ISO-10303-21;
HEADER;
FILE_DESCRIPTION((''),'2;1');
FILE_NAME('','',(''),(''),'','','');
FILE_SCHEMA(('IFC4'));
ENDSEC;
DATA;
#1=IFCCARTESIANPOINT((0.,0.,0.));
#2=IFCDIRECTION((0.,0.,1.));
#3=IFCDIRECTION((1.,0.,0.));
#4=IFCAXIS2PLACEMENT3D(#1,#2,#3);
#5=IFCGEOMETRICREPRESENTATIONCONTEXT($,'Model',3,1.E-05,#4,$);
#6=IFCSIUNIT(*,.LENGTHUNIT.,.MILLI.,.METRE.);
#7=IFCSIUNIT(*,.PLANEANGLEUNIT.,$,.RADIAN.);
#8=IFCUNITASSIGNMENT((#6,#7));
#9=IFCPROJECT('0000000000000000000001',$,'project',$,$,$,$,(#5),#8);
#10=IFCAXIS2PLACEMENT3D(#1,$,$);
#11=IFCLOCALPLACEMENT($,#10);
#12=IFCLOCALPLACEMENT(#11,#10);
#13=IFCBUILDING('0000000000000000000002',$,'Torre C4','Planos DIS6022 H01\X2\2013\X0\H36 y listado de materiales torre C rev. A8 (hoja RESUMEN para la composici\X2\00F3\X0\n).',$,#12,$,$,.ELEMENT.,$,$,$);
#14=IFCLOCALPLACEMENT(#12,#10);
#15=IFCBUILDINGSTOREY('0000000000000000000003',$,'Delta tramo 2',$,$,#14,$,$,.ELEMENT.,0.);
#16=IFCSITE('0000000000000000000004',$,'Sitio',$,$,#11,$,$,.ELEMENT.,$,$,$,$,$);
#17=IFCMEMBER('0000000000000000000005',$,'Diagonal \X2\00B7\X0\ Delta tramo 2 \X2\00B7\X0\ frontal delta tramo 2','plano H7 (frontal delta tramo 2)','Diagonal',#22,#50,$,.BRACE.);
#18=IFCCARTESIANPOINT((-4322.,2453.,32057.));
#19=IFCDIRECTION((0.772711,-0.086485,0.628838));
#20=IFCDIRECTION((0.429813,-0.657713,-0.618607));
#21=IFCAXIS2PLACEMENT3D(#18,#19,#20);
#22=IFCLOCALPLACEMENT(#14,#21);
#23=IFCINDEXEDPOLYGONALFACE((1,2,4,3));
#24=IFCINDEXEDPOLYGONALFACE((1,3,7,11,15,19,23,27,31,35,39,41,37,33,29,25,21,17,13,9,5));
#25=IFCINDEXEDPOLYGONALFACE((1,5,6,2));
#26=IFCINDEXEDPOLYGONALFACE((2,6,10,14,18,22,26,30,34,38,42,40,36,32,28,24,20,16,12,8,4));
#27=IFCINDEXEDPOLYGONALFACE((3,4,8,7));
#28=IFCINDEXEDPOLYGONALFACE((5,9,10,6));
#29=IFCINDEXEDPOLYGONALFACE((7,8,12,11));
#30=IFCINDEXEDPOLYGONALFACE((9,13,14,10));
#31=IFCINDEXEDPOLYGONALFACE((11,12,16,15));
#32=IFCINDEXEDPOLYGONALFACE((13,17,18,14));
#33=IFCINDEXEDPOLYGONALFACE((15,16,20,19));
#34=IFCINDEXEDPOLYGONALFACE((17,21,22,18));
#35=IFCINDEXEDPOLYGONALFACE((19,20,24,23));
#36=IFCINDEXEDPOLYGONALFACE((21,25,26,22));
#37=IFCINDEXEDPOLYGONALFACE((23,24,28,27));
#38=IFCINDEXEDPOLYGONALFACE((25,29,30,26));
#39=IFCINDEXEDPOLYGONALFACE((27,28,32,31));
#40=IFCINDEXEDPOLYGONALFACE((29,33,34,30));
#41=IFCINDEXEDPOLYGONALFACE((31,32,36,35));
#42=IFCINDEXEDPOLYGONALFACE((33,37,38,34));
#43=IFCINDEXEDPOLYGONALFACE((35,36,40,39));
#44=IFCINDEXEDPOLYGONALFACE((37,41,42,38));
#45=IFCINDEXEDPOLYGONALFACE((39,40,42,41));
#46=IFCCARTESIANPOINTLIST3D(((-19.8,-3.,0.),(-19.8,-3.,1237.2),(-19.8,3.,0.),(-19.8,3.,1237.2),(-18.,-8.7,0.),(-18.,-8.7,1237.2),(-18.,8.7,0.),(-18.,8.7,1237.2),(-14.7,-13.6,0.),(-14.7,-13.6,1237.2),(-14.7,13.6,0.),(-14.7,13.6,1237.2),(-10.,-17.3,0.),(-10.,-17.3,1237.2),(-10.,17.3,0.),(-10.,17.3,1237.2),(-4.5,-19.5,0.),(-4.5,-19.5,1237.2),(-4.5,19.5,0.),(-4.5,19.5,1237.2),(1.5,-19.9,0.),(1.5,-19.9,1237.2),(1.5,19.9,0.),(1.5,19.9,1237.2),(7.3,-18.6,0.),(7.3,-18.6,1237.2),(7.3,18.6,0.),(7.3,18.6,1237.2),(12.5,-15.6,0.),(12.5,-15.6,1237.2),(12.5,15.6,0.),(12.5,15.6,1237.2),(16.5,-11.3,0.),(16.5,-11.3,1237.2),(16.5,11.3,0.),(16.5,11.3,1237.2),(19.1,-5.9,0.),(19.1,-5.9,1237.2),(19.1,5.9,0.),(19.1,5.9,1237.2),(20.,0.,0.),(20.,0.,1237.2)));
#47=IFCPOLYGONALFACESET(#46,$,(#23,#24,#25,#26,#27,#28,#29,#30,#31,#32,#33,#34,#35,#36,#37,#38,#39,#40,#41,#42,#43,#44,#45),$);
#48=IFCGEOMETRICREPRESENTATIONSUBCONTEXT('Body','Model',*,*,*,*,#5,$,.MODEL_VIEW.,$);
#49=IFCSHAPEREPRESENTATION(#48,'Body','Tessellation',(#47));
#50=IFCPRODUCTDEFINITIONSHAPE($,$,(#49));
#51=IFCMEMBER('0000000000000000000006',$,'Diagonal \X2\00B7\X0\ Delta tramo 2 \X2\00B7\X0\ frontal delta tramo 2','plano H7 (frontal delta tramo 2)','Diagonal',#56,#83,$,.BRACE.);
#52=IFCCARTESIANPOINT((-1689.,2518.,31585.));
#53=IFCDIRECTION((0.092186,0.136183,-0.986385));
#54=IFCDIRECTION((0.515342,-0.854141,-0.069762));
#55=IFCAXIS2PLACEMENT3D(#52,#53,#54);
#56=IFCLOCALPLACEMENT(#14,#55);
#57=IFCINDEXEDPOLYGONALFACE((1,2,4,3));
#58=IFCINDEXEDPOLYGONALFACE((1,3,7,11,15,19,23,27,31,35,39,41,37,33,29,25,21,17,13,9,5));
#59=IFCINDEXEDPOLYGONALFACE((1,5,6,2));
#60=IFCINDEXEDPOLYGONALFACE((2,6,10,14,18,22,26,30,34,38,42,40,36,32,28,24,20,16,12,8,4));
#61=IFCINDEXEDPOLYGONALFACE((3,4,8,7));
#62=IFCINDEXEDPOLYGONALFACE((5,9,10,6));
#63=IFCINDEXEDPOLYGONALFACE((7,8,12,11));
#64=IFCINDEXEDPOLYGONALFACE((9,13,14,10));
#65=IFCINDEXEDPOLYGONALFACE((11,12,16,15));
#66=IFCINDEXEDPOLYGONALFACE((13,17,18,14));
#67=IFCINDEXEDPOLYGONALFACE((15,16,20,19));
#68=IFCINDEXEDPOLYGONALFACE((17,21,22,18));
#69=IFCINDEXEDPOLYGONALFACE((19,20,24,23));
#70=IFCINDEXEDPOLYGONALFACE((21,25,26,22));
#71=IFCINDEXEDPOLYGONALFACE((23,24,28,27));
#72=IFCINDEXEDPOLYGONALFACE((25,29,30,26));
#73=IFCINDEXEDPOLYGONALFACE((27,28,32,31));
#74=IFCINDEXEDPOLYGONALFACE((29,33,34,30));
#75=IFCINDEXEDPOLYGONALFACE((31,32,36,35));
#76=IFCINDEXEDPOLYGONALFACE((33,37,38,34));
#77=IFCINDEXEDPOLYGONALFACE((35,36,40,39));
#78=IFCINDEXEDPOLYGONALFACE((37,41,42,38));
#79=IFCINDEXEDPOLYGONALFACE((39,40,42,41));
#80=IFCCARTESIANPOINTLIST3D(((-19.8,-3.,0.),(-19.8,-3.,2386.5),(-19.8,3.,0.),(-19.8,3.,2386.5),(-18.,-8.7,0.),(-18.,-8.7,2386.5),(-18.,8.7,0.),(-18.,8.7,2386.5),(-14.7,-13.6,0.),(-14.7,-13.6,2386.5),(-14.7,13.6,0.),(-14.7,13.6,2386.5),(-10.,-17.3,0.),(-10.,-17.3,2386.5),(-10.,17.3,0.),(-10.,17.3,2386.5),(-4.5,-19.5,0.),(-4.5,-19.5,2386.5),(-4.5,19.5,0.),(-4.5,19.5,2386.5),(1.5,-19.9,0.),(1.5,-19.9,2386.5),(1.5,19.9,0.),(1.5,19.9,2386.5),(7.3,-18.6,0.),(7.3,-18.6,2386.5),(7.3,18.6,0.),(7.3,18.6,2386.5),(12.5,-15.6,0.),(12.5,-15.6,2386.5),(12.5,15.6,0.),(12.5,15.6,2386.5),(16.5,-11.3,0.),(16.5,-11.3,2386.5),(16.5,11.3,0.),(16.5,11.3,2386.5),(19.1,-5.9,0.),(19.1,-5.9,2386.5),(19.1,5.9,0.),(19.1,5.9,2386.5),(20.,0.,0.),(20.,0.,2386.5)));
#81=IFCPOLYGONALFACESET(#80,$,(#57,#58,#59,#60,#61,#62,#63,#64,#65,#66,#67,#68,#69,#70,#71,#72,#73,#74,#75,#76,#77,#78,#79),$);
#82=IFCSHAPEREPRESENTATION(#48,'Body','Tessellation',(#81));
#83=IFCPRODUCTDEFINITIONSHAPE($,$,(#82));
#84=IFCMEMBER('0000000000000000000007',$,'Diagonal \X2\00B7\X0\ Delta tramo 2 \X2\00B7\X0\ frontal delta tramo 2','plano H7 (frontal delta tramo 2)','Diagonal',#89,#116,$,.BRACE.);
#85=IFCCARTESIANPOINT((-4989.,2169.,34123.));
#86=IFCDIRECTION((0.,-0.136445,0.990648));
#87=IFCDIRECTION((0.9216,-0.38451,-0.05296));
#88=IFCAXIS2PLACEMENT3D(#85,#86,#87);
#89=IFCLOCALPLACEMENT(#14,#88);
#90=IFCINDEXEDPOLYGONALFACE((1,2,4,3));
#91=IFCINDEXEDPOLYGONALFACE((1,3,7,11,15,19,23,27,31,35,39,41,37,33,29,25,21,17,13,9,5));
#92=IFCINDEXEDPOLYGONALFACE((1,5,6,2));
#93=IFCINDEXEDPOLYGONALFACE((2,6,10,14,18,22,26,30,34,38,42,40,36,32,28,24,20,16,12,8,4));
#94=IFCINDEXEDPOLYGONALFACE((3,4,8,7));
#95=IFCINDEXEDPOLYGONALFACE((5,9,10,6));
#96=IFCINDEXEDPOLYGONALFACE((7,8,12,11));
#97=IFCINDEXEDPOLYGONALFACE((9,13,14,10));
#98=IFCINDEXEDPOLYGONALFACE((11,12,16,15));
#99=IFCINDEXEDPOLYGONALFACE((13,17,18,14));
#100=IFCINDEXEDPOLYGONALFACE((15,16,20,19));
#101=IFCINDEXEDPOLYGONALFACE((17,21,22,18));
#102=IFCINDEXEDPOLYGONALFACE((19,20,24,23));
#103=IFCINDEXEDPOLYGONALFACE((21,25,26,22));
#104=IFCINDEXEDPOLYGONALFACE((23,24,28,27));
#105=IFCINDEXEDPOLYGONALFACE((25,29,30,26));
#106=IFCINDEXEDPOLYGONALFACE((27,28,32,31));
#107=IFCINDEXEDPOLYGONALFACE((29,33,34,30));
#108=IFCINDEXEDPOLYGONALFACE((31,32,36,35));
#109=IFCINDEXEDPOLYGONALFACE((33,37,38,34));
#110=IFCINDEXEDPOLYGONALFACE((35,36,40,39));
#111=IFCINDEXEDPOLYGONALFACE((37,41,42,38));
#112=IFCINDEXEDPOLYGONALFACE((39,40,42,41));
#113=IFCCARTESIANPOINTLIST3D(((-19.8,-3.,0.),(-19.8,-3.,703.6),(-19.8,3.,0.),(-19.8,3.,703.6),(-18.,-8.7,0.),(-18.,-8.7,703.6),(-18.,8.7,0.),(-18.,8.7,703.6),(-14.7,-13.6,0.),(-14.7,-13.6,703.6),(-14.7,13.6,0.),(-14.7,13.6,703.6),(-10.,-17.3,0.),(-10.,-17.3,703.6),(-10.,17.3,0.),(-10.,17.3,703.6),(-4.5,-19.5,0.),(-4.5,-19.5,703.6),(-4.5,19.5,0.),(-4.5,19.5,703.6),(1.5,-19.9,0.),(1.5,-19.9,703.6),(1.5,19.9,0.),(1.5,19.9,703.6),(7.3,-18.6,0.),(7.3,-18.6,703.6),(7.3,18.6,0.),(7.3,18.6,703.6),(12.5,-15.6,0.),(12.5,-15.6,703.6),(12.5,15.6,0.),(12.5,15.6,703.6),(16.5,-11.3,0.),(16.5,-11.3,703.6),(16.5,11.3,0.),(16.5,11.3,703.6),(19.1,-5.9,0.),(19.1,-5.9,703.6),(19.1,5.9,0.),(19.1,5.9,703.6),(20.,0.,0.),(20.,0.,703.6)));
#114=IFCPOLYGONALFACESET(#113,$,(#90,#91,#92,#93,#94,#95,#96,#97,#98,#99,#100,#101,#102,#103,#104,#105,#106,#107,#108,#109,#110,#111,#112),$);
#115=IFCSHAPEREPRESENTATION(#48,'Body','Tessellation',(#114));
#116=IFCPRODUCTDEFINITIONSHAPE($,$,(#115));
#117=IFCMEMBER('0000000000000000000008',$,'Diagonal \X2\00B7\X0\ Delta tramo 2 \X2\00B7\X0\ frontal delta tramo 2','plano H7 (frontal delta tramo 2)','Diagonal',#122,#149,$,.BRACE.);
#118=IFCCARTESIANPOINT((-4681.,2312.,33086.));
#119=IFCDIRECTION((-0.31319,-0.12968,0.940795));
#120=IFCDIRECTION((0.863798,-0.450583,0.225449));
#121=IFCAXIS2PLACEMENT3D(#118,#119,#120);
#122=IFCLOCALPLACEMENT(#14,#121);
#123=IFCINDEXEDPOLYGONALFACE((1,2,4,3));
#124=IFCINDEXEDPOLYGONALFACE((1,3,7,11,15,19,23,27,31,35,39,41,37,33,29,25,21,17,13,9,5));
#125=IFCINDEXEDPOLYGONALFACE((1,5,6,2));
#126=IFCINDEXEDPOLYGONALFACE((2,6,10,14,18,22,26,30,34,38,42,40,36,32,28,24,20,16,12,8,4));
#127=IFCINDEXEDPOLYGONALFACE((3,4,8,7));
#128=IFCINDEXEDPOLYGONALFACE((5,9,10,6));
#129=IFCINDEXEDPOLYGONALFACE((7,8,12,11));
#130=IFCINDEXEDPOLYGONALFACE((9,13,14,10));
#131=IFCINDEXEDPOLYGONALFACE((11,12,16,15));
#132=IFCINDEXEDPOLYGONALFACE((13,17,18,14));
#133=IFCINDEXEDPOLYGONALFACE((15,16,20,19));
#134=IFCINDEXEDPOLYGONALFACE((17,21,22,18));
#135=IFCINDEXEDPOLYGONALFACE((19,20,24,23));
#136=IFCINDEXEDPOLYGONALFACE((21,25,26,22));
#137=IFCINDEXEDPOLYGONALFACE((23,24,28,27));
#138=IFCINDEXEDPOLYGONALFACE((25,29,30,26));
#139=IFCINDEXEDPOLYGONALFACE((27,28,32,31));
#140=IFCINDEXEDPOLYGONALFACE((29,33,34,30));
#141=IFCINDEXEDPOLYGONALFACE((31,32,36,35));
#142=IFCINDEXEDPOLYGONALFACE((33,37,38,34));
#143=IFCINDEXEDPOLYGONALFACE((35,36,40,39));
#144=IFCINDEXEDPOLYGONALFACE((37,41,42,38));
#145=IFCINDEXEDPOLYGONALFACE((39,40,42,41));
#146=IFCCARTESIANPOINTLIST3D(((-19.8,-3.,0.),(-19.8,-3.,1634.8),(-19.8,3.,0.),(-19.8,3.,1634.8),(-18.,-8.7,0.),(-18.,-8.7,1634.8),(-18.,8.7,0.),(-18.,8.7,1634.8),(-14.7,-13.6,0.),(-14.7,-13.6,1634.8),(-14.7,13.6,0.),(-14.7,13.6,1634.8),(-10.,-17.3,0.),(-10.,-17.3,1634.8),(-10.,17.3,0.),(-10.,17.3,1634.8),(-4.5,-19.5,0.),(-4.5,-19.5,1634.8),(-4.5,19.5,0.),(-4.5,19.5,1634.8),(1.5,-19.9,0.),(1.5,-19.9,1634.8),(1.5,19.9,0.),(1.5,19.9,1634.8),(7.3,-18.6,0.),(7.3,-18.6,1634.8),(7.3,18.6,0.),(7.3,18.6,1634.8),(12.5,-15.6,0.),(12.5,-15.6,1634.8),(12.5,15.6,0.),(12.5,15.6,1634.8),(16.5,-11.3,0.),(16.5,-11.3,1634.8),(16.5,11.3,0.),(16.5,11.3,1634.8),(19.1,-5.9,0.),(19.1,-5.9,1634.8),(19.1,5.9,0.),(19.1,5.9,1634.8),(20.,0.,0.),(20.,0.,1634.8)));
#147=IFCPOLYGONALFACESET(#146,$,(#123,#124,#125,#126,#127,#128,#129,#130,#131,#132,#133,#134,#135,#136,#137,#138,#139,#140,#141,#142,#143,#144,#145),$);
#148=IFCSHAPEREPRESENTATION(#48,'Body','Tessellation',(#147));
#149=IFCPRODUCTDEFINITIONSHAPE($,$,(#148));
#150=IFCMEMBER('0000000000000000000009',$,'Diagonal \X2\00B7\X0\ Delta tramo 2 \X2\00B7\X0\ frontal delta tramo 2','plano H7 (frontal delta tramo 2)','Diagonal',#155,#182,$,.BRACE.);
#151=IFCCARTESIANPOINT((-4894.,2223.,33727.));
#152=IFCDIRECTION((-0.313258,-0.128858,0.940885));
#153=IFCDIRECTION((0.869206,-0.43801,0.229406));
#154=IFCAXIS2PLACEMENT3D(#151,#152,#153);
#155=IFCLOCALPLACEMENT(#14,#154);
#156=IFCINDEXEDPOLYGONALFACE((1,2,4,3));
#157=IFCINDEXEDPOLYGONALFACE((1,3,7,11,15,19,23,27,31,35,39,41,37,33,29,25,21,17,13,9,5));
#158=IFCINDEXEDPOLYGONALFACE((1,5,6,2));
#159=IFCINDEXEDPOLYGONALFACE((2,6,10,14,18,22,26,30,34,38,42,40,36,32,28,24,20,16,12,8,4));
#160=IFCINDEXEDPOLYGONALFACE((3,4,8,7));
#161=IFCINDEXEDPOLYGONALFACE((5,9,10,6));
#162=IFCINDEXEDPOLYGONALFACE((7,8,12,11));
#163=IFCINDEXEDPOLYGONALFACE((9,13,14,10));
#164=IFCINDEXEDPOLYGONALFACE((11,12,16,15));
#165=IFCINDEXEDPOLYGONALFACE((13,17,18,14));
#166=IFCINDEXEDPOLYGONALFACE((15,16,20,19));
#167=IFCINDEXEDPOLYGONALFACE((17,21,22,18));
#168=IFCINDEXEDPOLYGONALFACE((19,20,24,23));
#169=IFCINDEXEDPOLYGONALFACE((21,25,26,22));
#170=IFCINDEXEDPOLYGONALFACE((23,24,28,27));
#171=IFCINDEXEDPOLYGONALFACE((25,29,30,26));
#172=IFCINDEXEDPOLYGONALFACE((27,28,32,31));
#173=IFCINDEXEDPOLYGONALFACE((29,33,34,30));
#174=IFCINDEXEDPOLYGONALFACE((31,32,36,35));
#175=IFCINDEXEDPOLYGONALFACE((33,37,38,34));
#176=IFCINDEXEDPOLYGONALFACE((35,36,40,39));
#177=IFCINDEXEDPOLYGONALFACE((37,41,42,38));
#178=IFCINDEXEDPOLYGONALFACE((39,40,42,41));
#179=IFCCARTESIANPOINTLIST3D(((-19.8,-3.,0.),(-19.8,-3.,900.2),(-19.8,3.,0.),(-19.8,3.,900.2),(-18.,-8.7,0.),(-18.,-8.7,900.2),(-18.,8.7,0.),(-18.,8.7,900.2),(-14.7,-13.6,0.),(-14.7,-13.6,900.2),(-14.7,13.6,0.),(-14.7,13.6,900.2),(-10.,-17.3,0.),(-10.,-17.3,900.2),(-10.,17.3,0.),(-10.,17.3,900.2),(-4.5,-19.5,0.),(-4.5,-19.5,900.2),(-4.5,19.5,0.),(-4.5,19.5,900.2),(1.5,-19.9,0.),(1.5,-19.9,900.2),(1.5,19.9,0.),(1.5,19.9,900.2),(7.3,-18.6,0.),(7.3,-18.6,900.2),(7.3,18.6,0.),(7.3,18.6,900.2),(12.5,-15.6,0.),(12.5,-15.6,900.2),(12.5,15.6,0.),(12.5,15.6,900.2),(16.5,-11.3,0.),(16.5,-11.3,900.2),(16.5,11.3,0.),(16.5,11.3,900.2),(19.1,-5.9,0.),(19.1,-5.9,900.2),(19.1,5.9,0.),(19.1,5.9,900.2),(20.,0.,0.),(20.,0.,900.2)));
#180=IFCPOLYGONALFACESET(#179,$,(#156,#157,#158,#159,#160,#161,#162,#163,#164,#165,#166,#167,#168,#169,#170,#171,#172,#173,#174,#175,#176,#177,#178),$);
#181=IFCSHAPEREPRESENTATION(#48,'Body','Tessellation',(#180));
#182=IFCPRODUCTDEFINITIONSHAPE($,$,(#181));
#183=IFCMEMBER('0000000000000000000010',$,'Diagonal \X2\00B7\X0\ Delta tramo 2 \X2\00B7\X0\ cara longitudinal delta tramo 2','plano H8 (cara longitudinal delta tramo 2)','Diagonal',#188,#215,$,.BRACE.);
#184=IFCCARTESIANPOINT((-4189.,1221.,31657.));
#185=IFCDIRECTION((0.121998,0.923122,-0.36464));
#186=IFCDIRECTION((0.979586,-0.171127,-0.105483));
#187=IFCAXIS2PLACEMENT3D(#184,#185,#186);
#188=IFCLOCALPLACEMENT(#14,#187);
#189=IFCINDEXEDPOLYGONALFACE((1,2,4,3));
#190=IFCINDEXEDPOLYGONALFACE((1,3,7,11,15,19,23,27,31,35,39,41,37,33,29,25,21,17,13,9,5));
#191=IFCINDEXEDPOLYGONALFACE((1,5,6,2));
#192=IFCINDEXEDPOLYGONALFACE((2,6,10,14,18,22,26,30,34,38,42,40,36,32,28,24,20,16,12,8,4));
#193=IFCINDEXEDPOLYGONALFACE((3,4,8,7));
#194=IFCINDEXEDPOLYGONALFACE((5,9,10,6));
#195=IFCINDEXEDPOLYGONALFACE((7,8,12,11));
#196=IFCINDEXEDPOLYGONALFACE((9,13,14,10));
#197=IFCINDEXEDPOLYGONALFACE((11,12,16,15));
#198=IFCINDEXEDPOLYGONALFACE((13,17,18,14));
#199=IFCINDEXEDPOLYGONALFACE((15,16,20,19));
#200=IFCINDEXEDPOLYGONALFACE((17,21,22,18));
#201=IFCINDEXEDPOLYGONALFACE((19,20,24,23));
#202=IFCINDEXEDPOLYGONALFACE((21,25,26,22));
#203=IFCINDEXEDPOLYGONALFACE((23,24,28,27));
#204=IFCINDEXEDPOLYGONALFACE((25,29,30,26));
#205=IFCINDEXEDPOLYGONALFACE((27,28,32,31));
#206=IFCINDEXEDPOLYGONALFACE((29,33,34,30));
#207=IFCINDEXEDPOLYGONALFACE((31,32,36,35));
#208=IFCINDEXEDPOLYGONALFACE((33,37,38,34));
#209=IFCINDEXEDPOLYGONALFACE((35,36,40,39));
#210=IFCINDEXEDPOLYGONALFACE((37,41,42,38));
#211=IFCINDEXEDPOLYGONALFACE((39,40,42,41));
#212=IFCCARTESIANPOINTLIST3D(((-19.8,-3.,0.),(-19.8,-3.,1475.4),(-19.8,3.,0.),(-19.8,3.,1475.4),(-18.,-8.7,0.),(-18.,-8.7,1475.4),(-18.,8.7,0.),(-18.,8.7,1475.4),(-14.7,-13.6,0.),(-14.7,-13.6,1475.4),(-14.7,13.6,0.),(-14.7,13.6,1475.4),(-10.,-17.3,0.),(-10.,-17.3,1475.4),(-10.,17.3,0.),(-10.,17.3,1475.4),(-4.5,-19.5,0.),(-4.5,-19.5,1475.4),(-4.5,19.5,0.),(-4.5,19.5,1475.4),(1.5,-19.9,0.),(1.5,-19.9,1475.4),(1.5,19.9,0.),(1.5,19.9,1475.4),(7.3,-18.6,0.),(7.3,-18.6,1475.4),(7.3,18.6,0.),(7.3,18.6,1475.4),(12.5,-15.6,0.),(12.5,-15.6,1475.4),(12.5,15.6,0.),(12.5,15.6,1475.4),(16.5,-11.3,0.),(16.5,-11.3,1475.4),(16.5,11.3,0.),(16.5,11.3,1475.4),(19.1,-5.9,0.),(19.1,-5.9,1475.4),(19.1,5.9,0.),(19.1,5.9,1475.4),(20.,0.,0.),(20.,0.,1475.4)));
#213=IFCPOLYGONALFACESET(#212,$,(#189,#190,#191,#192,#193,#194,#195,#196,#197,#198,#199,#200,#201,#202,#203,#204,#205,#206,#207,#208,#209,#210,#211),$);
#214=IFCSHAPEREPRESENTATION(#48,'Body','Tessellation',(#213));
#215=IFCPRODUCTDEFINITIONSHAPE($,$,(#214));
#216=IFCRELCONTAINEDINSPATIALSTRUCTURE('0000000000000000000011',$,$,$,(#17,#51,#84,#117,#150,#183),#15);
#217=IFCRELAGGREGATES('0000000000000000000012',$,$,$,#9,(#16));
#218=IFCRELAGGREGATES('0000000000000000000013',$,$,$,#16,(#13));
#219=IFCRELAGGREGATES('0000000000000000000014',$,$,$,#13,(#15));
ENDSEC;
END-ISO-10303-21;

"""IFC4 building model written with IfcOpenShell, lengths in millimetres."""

from ifc_helpers import new_model, si_unit, frame, origin, origin_with_axes, place, context, subcontext, project, spatial, circle, extrude, element, save


model = new_model("IFC4")

# Units and contexts
model_context = context("Model", 3, precision=1e-05, world=origin_with_axes())
body_context = subcontext(model_context, "Body", "Model", "MODEL_VIEW")
ifc_project = project(units=[si_unit("LENGTHUNIT", "METRE", prefix="MILLI"), si_unit("PLANEANGLEUNIT", "RADIAN")], contexts=[model_context])

# Site, building, storey
site_placement = place(None, origin())
site = spatial("IfcSite", under=ifc_project, at=site_placement, Name="Sitio", CompositionType="ELEMENT")
building_placement = place(site_placement, origin())
building = spatial("IfcBuilding", under=site, at=building_placement, Name="Torre C4", Description="Planos DIS6022 H01–H36 y listado de materiales torre C rev. A8 (hoja RESUMEN para la composición).", CompositionType="ELEMENT")
storey_placement = place(building_placement, origin())
storey = spatial("IfcBuildingStorey", under=building, at=storey_placement, Name="Delta tramo 2", CompositionType="ELEMENT", Elevation=0.0)

# Members
member_1_placement = place(storey_placement, frame((-4322.0, 2453.0, 32057.0), z_axis=(0.772711, -0.086485, 0.628838), x_axis=(0.429813, -0.657713, -0.618607)))
element("IfcMember", 1, at=member_1_placement, inside=storey, Name="Diagonal · Delta tramo 2 · frontal delta tramo 2", Description="plano H7 (frontal delta tramo 2)", ObjectType="Diagonal", PredefinedType="BRACE", context=body_context, shape_type="SweptSolid", body=[
    extrude(circle(Radius=20.0), None, (0.0, 0.0, 1.0), 1237.2),
])
member_2_placement = place(storey_placement, frame((-1689.0, 2518.0, 31585.0), z_axis=(0.092186, 0.136183, -0.986385), x_axis=(0.515342, -0.854141, -0.069762)))
element("IfcMember", 2, at=member_2_placement, inside=storey, Name="Diagonal · Delta tramo 2 · frontal delta tramo 2", Description="plano H7 (frontal delta tramo 2)", ObjectType="Diagonal", PredefinedType="BRACE", context=body_context, shape_type="SweptSolid", body=[
    extrude(circle(Radius=20.0), None, (0.0, 0.0, 1.0), 2386.5),
])
member_3_placement = place(storey_placement, frame((-4989.0, 2169.0, 34123.0), z_axis=(0.0, -0.136445, 0.990648), x_axis=(0.9216, -0.38451, -0.05296)))
element("IfcMember", 3, at=member_3_placement, inside=storey, Name="Diagonal · Delta tramo 2 · frontal delta tramo 2", Description="plano H7 (frontal delta tramo 2)", ObjectType="Diagonal", PredefinedType="BRACE", context=body_context, shape_type="SweptSolid", body=[
    extrude(circle(Radius=20.0), None, (0.0, 0.0, 1.0), 703.6),
])
member_4_placement = place(storey_placement, frame((-4681.0, 2312.0, 33086.0), z_axis=(-0.31319, -0.12968, 0.940795), x_axis=(0.863798, -0.450583, 0.225449)))
element("IfcMember", 4, at=member_4_placement, inside=storey, Name="Diagonal · Delta tramo 2 · frontal delta tramo 2", Description="plano H7 (frontal delta tramo 2)", ObjectType="Diagonal", PredefinedType="BRACE", context=body_context, shape_type="SweptSolid", body=[
    extrude(circle(Radius=20.0), None, (0.0, 0.0, 1.0), 1634.8),
])
member_5_placement = place(storey_placement, frame((-4894.0, 2223.0, 33727.0), z_axis=(-0.313258, -0.128858, 0.940885), x_axis=(0.869206, -0.43801, 0.229406)))
element("IfcMember", 5, at=member_5_placement, inside=storey, Name="Diagonal · Delta tramo 2 · frontal delta tramo 2", Description="plano H7 (frontal delta tramo 2)", ObjectType="Diagonal", PredefinedType="BRACE", context=body_context, shape_type="SweptSolid", body=[
    extrude(circle(Radius=20.0), None, (0.0, 0.0, 1.0), 900.2),
])
member_6_placement = place(storey_placement, frame((-4189.0, 1221.0, 31657.0), z_axis=(0.121998, 0.923122, -0.36464), x_axis=(0.979586, -0.171127, -0.105483)))
element("IfcMember", 6, at=member_6_placement, inside=storey, Name="Diagonal · Delta tramo 2 · cara longitudinal delta tramo 2", Description="plano H8 (cara longitudinal delta tramo 2)", ObjectType="Diagonal", PredefinedType="BRACE", context=body_context, shape_type="SweptSolid", body=[
    extrude(circle(Radius=20.0), None, (0.0, 0.0, 1.0), 1475.4),
])

save(model, "model.ifc")
